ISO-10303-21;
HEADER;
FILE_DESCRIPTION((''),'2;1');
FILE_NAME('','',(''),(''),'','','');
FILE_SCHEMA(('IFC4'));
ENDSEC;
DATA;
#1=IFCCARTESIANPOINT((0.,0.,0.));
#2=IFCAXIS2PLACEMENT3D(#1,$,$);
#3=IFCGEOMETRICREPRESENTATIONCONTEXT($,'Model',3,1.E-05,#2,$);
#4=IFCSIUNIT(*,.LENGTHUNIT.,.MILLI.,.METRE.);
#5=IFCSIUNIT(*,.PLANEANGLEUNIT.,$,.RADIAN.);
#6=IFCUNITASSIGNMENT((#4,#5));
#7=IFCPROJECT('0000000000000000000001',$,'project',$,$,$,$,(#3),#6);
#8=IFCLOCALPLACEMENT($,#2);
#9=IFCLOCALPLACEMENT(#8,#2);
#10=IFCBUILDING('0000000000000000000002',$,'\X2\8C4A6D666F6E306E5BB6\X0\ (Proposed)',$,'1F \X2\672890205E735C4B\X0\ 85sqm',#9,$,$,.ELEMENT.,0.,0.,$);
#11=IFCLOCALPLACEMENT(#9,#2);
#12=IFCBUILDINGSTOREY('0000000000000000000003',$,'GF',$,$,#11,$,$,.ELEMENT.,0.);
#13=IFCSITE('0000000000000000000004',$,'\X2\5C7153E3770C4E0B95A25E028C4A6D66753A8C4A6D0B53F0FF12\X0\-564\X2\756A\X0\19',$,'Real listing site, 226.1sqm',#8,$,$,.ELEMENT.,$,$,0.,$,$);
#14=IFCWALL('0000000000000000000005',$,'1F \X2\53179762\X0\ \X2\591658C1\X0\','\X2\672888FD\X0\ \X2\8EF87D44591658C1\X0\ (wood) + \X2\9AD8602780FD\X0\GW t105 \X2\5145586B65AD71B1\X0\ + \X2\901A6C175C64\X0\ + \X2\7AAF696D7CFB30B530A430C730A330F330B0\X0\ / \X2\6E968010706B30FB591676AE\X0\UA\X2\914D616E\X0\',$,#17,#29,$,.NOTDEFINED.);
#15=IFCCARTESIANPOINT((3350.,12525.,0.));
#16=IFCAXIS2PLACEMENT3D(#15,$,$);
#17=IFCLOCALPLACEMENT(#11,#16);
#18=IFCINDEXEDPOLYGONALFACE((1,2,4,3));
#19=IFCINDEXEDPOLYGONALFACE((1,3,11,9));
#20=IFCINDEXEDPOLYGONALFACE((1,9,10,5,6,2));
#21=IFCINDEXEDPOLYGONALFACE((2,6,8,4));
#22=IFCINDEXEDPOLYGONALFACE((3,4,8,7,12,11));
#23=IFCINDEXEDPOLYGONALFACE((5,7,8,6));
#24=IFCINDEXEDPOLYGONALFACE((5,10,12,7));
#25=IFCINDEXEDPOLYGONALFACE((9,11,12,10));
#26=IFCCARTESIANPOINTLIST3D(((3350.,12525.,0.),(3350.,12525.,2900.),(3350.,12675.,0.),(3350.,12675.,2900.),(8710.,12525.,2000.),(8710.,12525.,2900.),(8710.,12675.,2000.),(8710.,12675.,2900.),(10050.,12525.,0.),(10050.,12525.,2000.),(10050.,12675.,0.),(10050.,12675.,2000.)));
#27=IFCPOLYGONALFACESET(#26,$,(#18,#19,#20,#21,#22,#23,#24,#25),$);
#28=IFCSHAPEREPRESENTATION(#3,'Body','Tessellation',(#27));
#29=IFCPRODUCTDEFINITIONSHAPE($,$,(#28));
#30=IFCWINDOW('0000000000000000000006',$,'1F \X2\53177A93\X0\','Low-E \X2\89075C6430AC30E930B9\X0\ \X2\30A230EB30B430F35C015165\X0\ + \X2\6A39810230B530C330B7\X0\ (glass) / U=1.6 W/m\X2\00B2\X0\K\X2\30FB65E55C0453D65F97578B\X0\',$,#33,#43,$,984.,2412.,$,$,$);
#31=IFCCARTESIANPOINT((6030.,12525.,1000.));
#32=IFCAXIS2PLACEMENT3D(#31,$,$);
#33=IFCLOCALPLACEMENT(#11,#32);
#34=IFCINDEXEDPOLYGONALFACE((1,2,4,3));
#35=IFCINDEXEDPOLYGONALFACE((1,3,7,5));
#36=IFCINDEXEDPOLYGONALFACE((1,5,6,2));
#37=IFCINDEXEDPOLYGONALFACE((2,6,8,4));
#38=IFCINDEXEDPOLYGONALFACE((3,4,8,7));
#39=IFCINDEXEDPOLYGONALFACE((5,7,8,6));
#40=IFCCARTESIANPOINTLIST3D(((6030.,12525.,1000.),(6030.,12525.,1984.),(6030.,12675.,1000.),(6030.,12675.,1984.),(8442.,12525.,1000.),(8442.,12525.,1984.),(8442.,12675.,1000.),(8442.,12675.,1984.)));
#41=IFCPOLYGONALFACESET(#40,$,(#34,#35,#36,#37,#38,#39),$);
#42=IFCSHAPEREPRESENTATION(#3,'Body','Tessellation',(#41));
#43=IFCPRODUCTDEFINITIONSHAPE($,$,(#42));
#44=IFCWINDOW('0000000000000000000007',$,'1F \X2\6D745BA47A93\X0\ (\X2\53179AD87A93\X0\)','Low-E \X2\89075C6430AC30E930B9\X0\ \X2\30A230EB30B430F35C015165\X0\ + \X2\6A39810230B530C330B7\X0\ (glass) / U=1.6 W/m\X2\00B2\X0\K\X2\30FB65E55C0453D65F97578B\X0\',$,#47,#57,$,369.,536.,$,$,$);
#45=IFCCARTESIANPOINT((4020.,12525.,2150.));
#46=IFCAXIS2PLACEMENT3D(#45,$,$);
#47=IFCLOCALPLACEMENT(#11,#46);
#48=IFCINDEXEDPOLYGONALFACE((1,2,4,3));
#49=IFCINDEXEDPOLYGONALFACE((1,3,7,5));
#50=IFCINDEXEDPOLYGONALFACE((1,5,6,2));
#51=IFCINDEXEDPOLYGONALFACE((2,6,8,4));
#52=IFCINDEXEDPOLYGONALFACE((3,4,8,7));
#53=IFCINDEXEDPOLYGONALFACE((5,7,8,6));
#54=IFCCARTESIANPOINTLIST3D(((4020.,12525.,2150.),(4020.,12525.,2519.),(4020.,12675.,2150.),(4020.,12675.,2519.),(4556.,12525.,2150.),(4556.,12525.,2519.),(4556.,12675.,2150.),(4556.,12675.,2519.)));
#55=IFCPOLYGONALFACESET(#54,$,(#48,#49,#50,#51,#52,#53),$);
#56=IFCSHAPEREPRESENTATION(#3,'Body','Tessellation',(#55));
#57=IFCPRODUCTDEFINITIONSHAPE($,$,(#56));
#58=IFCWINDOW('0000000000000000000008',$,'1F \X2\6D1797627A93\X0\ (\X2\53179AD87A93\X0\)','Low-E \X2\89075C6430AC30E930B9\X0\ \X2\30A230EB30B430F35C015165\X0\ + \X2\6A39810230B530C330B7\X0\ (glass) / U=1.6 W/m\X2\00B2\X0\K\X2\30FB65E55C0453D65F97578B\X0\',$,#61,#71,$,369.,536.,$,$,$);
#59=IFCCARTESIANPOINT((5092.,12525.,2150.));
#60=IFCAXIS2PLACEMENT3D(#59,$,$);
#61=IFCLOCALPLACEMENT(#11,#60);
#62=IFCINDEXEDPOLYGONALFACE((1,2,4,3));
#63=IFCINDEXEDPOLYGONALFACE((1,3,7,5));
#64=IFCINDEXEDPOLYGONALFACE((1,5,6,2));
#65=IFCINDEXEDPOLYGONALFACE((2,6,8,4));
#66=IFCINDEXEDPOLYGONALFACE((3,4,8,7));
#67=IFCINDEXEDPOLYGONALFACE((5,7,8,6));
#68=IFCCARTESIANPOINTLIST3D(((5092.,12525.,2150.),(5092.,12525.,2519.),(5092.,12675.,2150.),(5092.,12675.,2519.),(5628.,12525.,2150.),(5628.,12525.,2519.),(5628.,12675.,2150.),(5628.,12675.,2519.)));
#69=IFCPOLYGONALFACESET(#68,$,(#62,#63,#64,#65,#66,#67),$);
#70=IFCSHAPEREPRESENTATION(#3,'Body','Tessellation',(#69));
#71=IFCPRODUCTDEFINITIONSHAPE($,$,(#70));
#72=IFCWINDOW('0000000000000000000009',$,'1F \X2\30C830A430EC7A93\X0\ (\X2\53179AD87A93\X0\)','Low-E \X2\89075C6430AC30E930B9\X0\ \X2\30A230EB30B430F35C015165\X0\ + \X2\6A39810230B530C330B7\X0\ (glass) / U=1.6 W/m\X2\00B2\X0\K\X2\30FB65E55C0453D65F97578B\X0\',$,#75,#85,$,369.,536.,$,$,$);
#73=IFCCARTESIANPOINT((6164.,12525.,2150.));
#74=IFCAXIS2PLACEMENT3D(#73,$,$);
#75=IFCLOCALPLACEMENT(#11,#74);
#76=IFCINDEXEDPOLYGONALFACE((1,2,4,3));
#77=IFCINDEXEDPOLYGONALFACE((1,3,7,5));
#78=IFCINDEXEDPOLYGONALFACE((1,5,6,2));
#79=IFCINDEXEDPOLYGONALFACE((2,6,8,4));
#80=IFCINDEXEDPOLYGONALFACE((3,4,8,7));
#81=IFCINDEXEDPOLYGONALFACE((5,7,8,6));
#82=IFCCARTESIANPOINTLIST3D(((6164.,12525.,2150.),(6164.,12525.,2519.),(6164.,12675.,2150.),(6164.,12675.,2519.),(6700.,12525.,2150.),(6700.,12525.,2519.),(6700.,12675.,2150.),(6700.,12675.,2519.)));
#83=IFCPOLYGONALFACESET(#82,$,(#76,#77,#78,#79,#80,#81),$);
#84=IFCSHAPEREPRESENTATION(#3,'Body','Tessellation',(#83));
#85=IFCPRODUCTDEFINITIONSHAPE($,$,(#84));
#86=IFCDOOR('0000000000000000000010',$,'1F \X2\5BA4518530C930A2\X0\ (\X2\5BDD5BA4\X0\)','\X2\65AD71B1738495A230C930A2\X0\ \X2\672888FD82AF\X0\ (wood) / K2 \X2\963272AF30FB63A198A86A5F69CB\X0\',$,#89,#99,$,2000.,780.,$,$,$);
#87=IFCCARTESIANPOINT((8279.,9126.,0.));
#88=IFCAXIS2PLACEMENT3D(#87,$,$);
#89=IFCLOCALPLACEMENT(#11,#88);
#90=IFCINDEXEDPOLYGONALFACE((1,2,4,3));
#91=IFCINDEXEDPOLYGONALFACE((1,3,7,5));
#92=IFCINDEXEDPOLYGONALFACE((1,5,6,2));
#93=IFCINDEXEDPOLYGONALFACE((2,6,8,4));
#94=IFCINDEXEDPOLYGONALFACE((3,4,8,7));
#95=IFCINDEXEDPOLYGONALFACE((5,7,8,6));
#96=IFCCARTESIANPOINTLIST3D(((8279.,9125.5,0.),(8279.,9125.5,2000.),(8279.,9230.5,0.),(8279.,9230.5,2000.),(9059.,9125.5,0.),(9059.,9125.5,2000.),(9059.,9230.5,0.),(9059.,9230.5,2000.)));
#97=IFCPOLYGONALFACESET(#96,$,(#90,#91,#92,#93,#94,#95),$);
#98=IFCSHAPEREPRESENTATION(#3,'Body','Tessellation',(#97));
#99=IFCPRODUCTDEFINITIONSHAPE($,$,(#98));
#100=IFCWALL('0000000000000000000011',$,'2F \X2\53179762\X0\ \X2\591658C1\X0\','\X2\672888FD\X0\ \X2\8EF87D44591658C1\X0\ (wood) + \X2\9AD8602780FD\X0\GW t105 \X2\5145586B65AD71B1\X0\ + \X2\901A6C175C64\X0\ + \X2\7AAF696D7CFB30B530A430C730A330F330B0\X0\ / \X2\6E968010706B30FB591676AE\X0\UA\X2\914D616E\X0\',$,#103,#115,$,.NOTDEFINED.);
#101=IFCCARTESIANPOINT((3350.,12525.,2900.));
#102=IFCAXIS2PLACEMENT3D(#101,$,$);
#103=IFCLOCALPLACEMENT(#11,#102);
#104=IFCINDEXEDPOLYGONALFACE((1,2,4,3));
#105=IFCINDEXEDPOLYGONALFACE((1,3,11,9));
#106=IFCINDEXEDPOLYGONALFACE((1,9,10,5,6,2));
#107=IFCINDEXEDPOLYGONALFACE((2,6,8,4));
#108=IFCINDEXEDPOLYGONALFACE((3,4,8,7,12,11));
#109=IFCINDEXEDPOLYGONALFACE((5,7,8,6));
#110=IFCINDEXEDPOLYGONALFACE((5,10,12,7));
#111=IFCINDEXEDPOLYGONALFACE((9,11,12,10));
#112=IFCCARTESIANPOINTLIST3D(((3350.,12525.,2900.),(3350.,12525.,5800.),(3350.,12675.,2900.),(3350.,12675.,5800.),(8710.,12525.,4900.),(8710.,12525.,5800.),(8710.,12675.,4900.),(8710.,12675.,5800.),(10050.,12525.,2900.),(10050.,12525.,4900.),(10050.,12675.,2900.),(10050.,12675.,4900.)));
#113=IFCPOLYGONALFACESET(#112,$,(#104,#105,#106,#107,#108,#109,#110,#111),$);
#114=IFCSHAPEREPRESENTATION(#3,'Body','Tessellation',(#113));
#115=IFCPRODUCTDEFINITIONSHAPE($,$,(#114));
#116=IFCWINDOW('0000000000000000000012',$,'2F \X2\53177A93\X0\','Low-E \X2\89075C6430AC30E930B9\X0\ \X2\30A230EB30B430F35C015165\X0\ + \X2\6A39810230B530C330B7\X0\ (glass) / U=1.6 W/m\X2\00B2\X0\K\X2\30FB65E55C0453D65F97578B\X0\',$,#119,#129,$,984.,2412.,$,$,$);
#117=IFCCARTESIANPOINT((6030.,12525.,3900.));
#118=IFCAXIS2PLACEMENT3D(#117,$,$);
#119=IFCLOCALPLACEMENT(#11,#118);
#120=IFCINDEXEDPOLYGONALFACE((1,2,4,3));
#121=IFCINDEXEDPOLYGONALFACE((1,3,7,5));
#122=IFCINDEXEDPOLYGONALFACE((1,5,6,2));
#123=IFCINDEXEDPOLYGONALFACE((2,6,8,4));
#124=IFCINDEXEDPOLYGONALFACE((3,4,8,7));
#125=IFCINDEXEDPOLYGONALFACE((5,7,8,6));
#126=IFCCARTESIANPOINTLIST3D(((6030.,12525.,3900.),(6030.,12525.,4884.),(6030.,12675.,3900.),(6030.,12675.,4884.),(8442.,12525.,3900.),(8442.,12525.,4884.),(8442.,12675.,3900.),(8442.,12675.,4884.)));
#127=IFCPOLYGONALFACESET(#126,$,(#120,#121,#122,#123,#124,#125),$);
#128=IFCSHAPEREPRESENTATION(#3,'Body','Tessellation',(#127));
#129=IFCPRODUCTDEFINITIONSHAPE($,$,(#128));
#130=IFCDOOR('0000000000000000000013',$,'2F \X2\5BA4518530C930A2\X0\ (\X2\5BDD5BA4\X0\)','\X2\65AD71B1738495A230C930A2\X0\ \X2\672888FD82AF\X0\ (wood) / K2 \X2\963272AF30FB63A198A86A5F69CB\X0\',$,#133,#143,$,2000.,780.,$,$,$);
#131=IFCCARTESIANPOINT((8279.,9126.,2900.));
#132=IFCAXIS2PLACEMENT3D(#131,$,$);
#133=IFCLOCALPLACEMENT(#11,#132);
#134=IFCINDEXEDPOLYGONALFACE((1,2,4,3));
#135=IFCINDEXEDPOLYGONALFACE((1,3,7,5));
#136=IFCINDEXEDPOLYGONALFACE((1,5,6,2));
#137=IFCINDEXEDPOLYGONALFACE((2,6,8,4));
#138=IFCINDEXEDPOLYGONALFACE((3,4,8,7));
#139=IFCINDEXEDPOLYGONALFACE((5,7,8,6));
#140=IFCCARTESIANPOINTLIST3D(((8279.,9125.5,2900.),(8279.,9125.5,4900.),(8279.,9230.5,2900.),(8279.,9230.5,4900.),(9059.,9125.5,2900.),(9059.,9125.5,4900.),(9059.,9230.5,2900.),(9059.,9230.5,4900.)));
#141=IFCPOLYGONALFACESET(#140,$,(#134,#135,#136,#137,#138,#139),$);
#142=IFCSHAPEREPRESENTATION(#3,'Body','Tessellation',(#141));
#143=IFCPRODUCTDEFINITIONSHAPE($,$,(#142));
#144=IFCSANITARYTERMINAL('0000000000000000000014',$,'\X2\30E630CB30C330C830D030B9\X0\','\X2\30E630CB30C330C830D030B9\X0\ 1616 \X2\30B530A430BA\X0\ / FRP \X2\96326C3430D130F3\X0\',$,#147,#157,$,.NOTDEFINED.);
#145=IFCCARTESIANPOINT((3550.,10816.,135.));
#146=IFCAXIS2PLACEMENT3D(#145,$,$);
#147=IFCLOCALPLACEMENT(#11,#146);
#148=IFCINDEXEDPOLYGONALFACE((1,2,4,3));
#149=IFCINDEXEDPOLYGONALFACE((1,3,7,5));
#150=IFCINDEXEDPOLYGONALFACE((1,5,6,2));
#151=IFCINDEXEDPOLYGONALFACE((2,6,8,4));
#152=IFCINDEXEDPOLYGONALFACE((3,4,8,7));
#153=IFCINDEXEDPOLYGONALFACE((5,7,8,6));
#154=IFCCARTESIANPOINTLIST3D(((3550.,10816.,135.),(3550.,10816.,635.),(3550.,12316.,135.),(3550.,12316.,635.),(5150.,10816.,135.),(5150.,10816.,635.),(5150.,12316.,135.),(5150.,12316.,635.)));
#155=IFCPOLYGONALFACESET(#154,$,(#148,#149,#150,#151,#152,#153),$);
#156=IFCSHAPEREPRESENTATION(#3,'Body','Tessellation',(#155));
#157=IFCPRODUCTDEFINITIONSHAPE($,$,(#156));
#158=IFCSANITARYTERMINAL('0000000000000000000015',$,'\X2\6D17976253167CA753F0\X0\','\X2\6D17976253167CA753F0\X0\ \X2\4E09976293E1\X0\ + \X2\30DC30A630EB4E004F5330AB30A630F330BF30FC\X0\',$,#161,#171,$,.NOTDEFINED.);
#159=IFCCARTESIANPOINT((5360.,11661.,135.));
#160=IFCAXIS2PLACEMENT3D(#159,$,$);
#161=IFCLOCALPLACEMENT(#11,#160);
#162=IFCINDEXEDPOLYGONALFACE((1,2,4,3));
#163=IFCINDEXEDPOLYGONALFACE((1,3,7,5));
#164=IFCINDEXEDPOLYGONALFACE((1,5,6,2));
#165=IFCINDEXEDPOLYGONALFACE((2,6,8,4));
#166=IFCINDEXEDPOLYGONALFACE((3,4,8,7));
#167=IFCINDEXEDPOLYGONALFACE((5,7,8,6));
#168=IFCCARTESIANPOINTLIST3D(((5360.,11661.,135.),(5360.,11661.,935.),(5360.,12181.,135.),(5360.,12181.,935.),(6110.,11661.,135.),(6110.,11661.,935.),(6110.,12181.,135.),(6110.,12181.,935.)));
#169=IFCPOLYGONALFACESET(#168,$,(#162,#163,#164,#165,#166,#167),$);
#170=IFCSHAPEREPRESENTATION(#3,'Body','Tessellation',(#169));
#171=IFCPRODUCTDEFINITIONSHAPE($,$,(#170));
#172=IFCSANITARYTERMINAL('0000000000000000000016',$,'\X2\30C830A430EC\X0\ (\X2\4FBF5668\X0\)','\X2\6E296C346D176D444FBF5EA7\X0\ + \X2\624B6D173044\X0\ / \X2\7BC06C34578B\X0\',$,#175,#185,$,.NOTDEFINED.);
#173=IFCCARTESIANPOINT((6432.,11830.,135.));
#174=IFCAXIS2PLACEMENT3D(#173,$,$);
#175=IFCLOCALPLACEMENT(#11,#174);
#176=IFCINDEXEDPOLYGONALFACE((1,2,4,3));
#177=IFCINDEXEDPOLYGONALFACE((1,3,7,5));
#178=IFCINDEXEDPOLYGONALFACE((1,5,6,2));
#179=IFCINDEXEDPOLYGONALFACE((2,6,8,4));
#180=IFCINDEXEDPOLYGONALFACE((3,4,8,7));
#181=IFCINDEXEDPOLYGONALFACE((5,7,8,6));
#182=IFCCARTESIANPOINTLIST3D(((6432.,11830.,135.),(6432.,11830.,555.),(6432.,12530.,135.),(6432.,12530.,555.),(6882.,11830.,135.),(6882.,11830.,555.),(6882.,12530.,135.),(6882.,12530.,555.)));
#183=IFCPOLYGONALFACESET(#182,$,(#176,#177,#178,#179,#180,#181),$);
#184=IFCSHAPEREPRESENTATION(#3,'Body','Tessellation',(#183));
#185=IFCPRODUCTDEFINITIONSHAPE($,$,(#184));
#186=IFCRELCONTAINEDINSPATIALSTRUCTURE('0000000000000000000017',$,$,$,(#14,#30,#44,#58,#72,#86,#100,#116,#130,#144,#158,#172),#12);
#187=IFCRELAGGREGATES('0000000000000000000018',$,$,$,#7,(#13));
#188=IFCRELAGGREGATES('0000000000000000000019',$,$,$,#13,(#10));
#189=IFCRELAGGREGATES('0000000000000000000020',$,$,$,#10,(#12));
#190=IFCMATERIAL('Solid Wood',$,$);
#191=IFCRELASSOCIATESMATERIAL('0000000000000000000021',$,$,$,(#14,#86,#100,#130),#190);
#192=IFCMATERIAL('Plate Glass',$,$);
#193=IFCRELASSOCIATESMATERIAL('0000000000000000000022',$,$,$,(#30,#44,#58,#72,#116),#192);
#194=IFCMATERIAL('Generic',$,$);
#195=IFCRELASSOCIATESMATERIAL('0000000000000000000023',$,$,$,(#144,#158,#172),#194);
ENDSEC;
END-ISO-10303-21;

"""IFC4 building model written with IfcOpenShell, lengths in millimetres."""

from ifc_helpers import new_model, si_unit, frame, frame_2d, origin, place, context, project, spatial, rectangle, extrude, material, element, fill, save


model = new_model("IFC4")

# Units and contexts
model_context = context("Model", 3, precision=1e-05, world=origin())
ifc_project = project(units=[si_unit("LENGTHUNIT", "METRE", prefix="MILLI"), si_unit("PLANEANGLEUNIT", "RADIAN")], contexts=[model_context])

# Site, building, storey
site_placement = place(None, origin())
site = spatial("IfcSite", under=ifc_project, at=site_placement, Name="山口県下関市豊浦町豊洋台２-564番19", ObjectType="Real listing site, 226.1sqm", CompositionType="ELEMENT", RefElevation=0.0)
building_placement = place(site_placement, origin())
building = spatial("IfcBuilding", under=site, at=building_placement, Name="豊浦潮の家 (Proposed)", ObjectType="1F 木造平屋 85sqm", CompositionType="ELEMENT", ElevationOfRefHeight=0.0, ElevationOfTerrain=0.0)
storey_placement = place(building_placement, origin())
storey = spatial("IfcBuildingStorey", under=building, at=storey_placement, Name="GF", CompositionType="ELEMENT", Elevation=0.0)

# Wall, openings, windows
ifc_material_1 = material(Name="Solid Wood")
wall_1_placement = place(storey_placement, frame((3350.0, 12525.0, 0.0)))
wall_1 = element("IfcWall", 1, at=wall_1_placement, inside=storey, material=ifc_material_1, Name="1F 北面 外壁", Description="木製 軸組外壁 (wood) + 高性能GW t105 充填断熱 + 通気層 + 窯業系サイディング / 準耐火・外皮UA配慮", PredefinedType="NOTDEFINED", context=model_context, shape_type="SweptSolid", body=[
    extrude(rectangle(XDim=6700.0, YDim=150.0, at=frame_2d((3350.0, 75.0))), frame((3350.0, 12525.0, 0.0)), (0.0, 0.0, 1.0), 2900.0),
])
opening_1_placement = place(storey_placement, frame((6030.0, 12525.0, 1000.0)))
opening_1 = element("IfcOpeningElement", 2, at=opening_1_placement, cuts=wall_1, PredefinedType="NOTDEFINED", context=model_context, shape_type="SweptSolid", body=[
    extrude(rectangle(XDim=2412.0, YDim=150.0, at=frame_2d((1206.0, 75.0))), frame((6030.0, 12525.0, 1000.0)), (0.0, 0.0, 1.0), 984.0),
])
opening_2_placement = place(storey_placement, frame((4020.0, 12525.0, 2150.0)))
opening_2 = element("IfcOpeningElement", 3, at=opening_2_placement, cuts=wall_1, PredefinedType="NOTDEFINED", context=model_context, shape_type="SweptSolid", body=[
    extrude(rectangle(XDim=536.0, YDim=150.0, at=frame_2d((268.0, 75.0))), frame((4020.0, 12525.0, 2150.0)), (0.0, 0.0, 1.0), 369.0),
])
opening_3_placement = place(storey_placement, frame((5092.0, 12525.0, 2150.0)))
opening_3 = element("IfcOpeningElement", 4, at=opening_3_placement, cuts=wall_1, PredefinedType="NOTDEFINED", context=model_context, shape_type="SweptSolid", body=[
    extrude(rectangle(XDim=536.0, YDim=150.0, at=frame_2d((268.0, 75.0))), frame((5092.0, 12525.0, 2150.0)), (0.0, 0.0, 1.0), 369.0),
])
opening_4_placement = place(storey_placement, frame((6164.0, 12525.0, 2150.0)))
opening_4 = element("IfcOpeningElement", 5, at=opening_4_placement, cuts=wall_1, PredefinedType="NOTDEFINED", context=model_context, shape_type="SweptSolid", body=[
    extrude(rectangle(XDim=536.0, YDim=150.0, at=frame_2d((268.0, 75.0))), frame((6164.0, 12525.0, 2150.0)), (0.0, 0.0, 1.0), 369.0),
])
ifc_material_2 = material(Name="Plate Glass")
window_1_placement = place(storey_placement, frame((6030.0, 12525.0, 1000.0)))
window_1 = element("IfcWindow", 6, at=window_1_placement, inside=storey, material=ifc_material_2, Name="1F 北窓", Description="Low-E 複層ガラス アルゴン封入 + 樹脂サッシ (glass) / U=1.6 W/m²K・日射取得型", OverallHeight=984.0, OverallWidth=2412.0, context=model_context, shape_type="SweptSolid", body=[
    extrude(rectangle(XDim=2412.0, YDim=150.0, at=frame_2d((1206.0, 75.0))), frame((6030.0, 12525.0, 1000.0)), (0.0, 0.0, 1.0), 984.0),
])
fill(opening_1, window_1)
window_2_placement = place(storey_placement, frame((4020.0, 12525.0, 2150.0)))
window_2 = element("IfcWindow", 7, at=window_2_placement, inside=storey, material=ifc_material_2, Name="1F 浴室窓 (北高窓)", Description="Low-E 複層ガラス アルゴン封入 + 樹脂サッシ (glass) / U=1.6 W/m²K・日射取得型", OverallHeight=369.0, OverallWidth=536.0, context=model_context, shape_type="SweptSolid", body=[
    extrude(rectangle(XDim=536.0, YDim=150.0, at=frame_2d((268.0, 75.0))), frame((4020.0, 12525.0, 2150.0)), (0.0, 0.0, 1.0), 369.0),
])
fill(opening_2, window_2)
window_3_placement = place(storey_placement, frame((5092.0, 12525.0, 2150.0)))
window_3 = element("IfcWindow", 8, at=window_3_placement, inside=storey, material=ifc_material_2, Name="1F 洗面窓 (北高窓)", Description="Low-E 複層ガラス アルゴン封入 + 樹脂サッシ (glass) / U=1.6 W/m²K・日射取得型", OverallHeight=369.0, OverallWidth=536.0, context=model_context, shape_type="SweptSolid", body=[
    extrude(rectangle(XDim=536.0, YDim=150.0, at=frame_2d((268.0, 75.0))), frame((5092.0, 12525.0, 2150.0)), (0.0, 0.0, 1.0), 369.0),
])
fill(opening_3, window_3)
window_4_placement = place(storey_placement, frame((6164.0, 12525.0, 2150.0)))
window_4 = element("IfcWindow", 9, at=window_4_placement, inside=storey, material=ifc_material_2, Name="1F トイレ窓 (北高窓)", Description="Low-E 複層ガラス アルゴン封入 + 樹脂サッシ (glass) / U=1.6 W/m²K・日射取得型", OverallHeight=369.0, OverallWidth=536.0, context=model_context, shape_type="SweptSolid", body=[
    extrude(rectangle(XDim=536.0, YDim=150.0, at=frame_2d((268.0, 75.0))), frame((6164.0, 12525.0, 2150.0)), (0.0, 0.0, 1.0), 369.0),
])
fill(opening_4, window_4)

# Door
door_1_placement = place(storey_placement, frame((8279.0, 9126.0, 0.0)))
element("IfcDoor", 10, at=door_1_placement, inside=storey, material=ifc_material_1, Name="1F 室内ドア (寝室)", Description="断熱玄関ドア 木製芯 (wood) / K2 防犯・採風機構", OverallHeight=2000.0, OverallWidth=780.0, context=model_context, shape_type="SweptSolid", body=[
    extrude(rectangle(XDim=780.0, YDim=105.0, at=frame_2d((390.0, 52.0))), frame((8279.0, 9126.0, 0.0)), (0.0, 0.0, 1.0), 2000.0),
])

# Wall, opening, window
wall_2_placement = place(storey_placement, frame((3350.0, 12525.0, 2900.0)))
wall_2 = element("IfcWall", 11, at=wall_2_placement, inside=storey, material=ifc_material_1, Name="2F 北面 外壁", Description="木製 軸組外壁 (wood) + 高性能GW t105 充填断熱 + 通気層 + 窯業系サイディング / 準耐火・外皮UA配慮", PredefinedType="NOTDEFINED", context=model_context, shape_type="SweptSolid", body=[
    extrude(rectangle(XDim=6700.0, YDim=150.0, at=frame_2d((3350.0, 75.0))), frame((3350.0, 12525.0, 2900.0)), (0.0, 0.0, 1.0), 2900.0),
])
opening_5_placement = place(storey_placement, frame((6030.0, 12525.0, 3900.0)))
opening_5 = element("IfcOpeningElement", 12, at=opening_5_placement, cuts=wall_2, PredefinedType="NOTDEFINED", context=model_context, shape_type="SweptSolid", body=[
    extrude(rectangle(XDim=2412.0, YDim=150.0, at=frame_2d((1206.0, 75.0))), frame((6030.0, 12525.0, 3900.0)), (0.0, 0.0, 1.0), 984.0),
])
window_5_placement = place(storey_placement, frame((6030.0, 12525.0, 3900.0)))
window_5 = element("IfcWindow", 13, at=window_5_placement, inside=storey, material=ifc_material_2, Name="2F 北窓", Description="Low-E 複層ガラス アルゴン封入 + 樹脂サッシ (glass) / U=1.6 W/m²K・日射取得型", OverallHeight=984.0, OverallWidth=2412.0, context=model_context, shape_type="SweptSolid", body=[
    extrude(rectangle(XDim=2412.0, YDim=150.0, at=frame_2d((1206.0, 75.0))), frame((6030.0, 12525.0, 3900.0)), (0.0, 0.0, 1.0), 984.0),
])
fill(opening_5, window_5)

# Door
door_2_placement = place(storey_placement, frame((8279.0, 9126.0, 2900.0)))
element("IfcDoor", 14, at=door_2_placement, inside=storey, material=ifc_material_1, Name="2F 室内ドア (寝室)", Description="断熱玄関ドア 木製芯 (wood) / K2 防犯・採風機構", OverallHeight=2000.0, OverallWidth=780.0, context=model_context, shape_type="SweptSolid", body=[
    extrude(rectangle(XDim=780.0, YDim=105.0, at=frame_2d((390.0, 52.0))), frame((8279.0, 9126.0, 2900.0)), (0.0, 0.0, 1.0), 2000.0),
])

# Sanitary terminals
ifc_material_3 = material(Name="Generic")
sanitary_terminal_1_placement = place(storey_placement, frame((3550.0, 10816.0, 135.0)))
element("IfcSanitaryTerminal", 15, at=sanitary_terminal_1_placement, inside=storey, material=ifc_material_3, Name="ユニットバス", Description="ユニットバス 1616 サイズ / FRP 防水パン", PredefinedType="NOTDEFINED", context=model_context, shape_type="SweptSolid", body=[
    extrude(rectangle(XDim=1600.0, YDim=1500.0, at=frame_2d((800.0, 750.0))), frame((3550.0, 10816.0, 135.0)), (0.0, 0.0, 1.0), 500.0),
])
sanitary_terminal_2_placement = place(storey_placement, frame((5360.0, 11661.0, 135.0)))
element("IfcSanitaryTerminal", 16, at=sanitary_terminal_2_placement, inside=storey, material=ifc_material_3, Name="洗面化粧台", Description="洗面化粧台 三面鏡 + ボウル一体カウンター", PredefinedType="NOTDEFINED", context=model_context, shape_type="SweptSolid", body=[
    extrude(rectangle(XDim=750.0, YDim=520.0, at=frame_2d((375.0, 260.0))), frame((5360.0, 11661.0, 135.0)), (0.0, 0.0, 1.0), 800.0),
])
sanitary_terminal_3_placement = place(storey_placement, frame((6432.0, 11830.0, 135.0)))
element("IfcSanitaryTerminal", 17, at=sanitary_terminal_3_placement, inside=storey, material=ifc_material_3, Name="トイレ (便器)", Description="温水洗浄便座 + 手洗い / 節水型", PredefinedType="NOTDEFINED", context=model_context, shape_type="SweptSolid", body=[
    extrude(rectangle(XDim=450.0, YDim=700.0, at=frame_2d((225.0, 350.0))), frame((6432.0, 11830.0, 135.0)), (0.0, 0.0, 1.0), 420.0),
])

save(model, "model.ifc")
